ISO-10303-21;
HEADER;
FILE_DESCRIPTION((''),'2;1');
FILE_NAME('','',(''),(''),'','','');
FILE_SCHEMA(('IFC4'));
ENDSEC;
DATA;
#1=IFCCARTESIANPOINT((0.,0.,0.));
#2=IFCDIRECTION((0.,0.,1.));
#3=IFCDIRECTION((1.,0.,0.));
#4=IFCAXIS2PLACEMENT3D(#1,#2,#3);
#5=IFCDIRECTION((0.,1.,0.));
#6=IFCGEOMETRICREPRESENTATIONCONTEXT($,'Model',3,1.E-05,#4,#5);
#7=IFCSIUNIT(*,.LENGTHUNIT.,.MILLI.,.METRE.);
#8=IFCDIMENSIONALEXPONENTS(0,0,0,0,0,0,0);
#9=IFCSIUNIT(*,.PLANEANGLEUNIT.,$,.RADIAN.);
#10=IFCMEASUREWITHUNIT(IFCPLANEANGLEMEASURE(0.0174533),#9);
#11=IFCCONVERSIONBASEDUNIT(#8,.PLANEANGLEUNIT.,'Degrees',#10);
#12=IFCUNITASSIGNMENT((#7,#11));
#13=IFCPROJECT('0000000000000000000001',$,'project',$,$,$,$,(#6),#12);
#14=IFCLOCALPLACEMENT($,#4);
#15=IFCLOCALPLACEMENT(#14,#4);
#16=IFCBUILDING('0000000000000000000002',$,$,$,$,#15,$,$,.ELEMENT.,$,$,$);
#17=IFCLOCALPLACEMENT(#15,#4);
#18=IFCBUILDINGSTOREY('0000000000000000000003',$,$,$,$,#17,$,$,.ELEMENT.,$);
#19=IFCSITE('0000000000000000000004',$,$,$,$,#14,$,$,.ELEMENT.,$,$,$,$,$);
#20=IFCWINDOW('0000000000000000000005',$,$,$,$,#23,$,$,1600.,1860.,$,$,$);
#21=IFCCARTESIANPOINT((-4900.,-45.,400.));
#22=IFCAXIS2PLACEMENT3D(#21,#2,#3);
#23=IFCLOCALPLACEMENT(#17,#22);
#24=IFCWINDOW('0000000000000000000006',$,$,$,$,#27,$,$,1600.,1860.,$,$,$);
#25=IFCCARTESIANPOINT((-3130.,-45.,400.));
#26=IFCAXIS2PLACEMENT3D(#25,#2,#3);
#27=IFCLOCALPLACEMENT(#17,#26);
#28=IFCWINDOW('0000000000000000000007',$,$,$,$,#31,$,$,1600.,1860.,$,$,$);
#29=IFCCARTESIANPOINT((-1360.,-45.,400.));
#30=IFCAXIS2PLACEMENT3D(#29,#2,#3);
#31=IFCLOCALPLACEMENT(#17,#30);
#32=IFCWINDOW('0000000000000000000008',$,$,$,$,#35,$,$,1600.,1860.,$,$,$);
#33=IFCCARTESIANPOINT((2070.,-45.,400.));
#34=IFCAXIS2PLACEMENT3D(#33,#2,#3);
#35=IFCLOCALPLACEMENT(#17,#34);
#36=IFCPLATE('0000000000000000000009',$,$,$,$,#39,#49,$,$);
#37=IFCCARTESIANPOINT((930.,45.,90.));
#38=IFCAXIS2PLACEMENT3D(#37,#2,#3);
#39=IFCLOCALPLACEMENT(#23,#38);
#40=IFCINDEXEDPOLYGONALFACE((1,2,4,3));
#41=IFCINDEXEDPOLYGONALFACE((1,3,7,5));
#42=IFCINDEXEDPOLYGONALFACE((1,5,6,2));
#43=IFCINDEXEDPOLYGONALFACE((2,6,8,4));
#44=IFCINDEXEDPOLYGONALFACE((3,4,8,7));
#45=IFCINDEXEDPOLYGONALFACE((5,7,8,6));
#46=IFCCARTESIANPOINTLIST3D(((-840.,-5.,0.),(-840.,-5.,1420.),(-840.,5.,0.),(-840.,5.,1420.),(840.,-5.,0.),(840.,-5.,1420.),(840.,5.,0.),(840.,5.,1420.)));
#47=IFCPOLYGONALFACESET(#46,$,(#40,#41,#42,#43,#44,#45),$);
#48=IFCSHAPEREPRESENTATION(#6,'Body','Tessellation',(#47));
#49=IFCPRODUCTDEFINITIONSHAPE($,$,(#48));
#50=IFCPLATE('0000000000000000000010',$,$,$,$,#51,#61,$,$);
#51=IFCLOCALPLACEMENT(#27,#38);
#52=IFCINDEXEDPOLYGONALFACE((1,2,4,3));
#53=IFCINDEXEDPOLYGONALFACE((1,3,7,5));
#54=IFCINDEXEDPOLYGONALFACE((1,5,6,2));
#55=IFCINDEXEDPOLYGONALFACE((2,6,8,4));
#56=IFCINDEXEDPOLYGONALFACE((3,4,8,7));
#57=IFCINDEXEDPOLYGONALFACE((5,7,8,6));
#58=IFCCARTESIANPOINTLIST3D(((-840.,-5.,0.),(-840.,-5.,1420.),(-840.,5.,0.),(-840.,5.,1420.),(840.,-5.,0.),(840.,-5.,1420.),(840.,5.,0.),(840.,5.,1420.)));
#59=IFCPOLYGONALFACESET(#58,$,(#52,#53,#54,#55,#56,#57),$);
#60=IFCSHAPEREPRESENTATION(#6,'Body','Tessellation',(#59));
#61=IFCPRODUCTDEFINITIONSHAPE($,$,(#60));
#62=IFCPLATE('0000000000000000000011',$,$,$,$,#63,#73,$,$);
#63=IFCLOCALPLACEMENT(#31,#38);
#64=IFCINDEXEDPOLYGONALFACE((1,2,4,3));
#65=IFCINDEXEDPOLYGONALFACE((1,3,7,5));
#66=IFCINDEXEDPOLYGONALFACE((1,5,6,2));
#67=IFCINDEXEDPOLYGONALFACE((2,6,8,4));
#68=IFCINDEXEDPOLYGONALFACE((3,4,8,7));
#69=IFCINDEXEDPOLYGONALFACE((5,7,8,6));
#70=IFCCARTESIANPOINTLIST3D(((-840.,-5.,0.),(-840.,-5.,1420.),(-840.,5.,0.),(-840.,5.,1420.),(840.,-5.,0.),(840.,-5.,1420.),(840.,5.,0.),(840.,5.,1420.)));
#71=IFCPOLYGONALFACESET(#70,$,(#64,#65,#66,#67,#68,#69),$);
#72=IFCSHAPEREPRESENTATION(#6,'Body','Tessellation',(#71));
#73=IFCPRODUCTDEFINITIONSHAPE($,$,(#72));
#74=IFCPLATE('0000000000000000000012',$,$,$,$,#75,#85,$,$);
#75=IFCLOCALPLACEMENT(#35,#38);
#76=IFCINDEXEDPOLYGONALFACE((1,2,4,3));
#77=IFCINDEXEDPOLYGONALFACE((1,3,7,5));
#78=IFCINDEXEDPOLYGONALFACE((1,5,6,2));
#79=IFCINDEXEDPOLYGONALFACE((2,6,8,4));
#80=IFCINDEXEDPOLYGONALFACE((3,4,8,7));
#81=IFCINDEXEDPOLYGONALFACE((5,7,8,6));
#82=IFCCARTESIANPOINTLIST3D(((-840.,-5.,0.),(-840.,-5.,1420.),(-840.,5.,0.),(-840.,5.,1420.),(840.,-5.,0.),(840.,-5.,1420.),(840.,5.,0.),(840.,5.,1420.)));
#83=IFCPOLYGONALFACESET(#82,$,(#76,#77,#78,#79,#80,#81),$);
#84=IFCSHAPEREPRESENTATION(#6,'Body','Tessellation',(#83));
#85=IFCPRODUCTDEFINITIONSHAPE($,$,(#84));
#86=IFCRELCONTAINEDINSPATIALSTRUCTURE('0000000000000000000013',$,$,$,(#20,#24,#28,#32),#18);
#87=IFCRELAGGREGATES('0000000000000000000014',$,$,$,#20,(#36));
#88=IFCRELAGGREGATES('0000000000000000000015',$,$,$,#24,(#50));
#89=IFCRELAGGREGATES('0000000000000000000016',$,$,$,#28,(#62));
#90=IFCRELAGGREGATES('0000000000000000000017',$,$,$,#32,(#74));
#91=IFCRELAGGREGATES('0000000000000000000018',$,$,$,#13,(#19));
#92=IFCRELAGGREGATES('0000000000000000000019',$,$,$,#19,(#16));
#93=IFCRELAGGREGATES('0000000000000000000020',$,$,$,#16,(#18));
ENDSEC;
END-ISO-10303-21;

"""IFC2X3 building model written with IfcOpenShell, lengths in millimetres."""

from ifc_helpers import new_model, entity, si_unit, converted_unit, direction, frame, origin_with_axes, place, context, project, spatial, polyline, outline, extrude, element, aggregate, save


model = new_model("IFC2X3")

# Units and contexts
model_context = context("Model", 3, precision=1e-05, world=origin_with_axes(), true_north=direction((0.0, 1.0, 0.0)))
ifc_project = project(units=[si_unit("LENGTHUNIT", "METRE", prefix="MILLI"), converted_unit("PLANEANGLEUNIT", "Degrees", entity("IfcPlaneAngleMeasure", 0.0174533), si_unit("PLANEANGLEUNIT", "RADIAN"), dimensions=[0, 0, 0, 0, 0, 0, 0])], contexts=[model_context])

# Site, building, storey
placement = place(None, origin_with_axes())
site = spatial("IfcSite", under=ifc_project, at=placement, CompositionType="ELEMENT")
building_placement = place(placement, origin_with_axes())
building = spatial("IfcBuilding", under=site, at=building_placement, CompositionType="ELEMENT")
storey_placement = place(building_placement, origin_with_axes())
storey = spatial("IfcBuildingStorey", under=building, at=storey_placement, CompositionType="ELEMENT")

# Windows
window_1_placement = place(storey_placement, frame((-4900.0, -45.0, 400.0), z_axis=(0.0, 0.0, 1.0), x_axis=(1.0, 0.0, 0.0)))
window_1 = element("IfcWindow", 1, at=window_1_placement, inside=storey, OverallHeight=1600.0, OverallWidth=1860.0)
window_2_placement = place(storey_placement, frame((-3130.0, -45.0, 400.0), z_axis=(0.0, 0.0, 1.0), x_axis=(1.0, 0.0, 0.0)))
window_2 = element("IfcWindow", 2, at=window_2_placement, inside=storey, OverallHeight=1600.0, OverallWidth=1860.0)
window_3_placement = place(storey_placement, frame((-1360.0, -45.0, 400.0), z_axis=(0.0, 0.0, 1.0), x_axis=(1.0, 0.0, 0.0)))
window_3 = element("IfcWindow", 3, at=window_3_placement, inside=storey, OverallHeight=1600.0, OverallWidth=1860.0)
window_4_placement = place(storey_placement, frame((2070.0, -45.0, 400.0), z_axis=(0.0, 0.0, 1.0), x_axis=(1.0, 0.0, 0.0)))
window_4 = element("IfcWindow", 4, at=window_4_placement, inside=storey, OverallHeight=1600.0, OverallWidth=1860.0)

# Plates
plate_1_placement = place(window_1_placement, frame((930.0, 45.0, 90.0), z_axis=(0.0, 0.0, 1.0), x_axis=(1.0, 0.0, 0.0)))
plate_1 = element("IfcPlate", 5, at=plate_1_placement, context=model_context, shape_type="SweptSolid", body=[
    extrude(outline(polyline([(-840.0, -5.0), (840.0, -5.0), (840.0, 5.0), (-840.0, 5.0), (-840.0, -5.0), (-840.0, -5.0)])), origin_with_axes(), (0.0, 0.0, 1.0), 1420.0),
])
aggregate(window_1, [plate_1])
plate_2_placement = place(window_2_placement, frame((930.0, 45.0, 90.0), z_axis=(0.0, 0.0, 1.0), x_axis=(1.0, 0.0, 0.0)))
plate_2 = element("IfcPlate", 6, at=plate_2_placement, context=model_context, shape_type="SweptSolid", body=[
    extrude(outline(polyline([(-840.0, -5.0), (840.0, -5.0), (840.0, 5.0), (-840.0, 5.0), (-840.0, -5.0), (-840.0, -5.0)])), origin_with_axes(), (0.0, 0.0, 1.0), 1420.0),
])
aggregate(window_2, [plate_2])
plate_3_placement = place(window_3_placement, frame((930.0, 45.0, 90.0), z_axis=(0.0, 0.0, 1.0), x_axis=(1.0, 0.0, 0.0)))
plate_3 = element("IfcPlate", 7, at=plate_3_placement, context=model_context, shape_type="SweptSolid", body=[
    extrude(outline(polyline([(-840.0, -5.0), (840.0, -5.0), (840.0, 5.0), (-840.0, 5.0), (-840.0, -5.0), (-840.0, -5.0)])), origin_with_axes(), (0.0, 0.0, 1.0), 1420.0),
])
aggregate(window_3, [plate_3])
plate_4_placement = place(window_4_placement, frame((930.0, 45.0, 90.0), z_axis=(0.0, 0.0, 1.0), x_axis=(1.0, 0.0, 0.0)))
plate_4 = element("IfcPlate", 8, at=plate_4_placement, context=model_context, shape_type="SweptSolid", body=[
    extrude(outline(polyline([(-840.0, -5.0), (840.0, -5.0), (840.0, 5.0), (-840.0, 5.0), (-840.0, -5.0), (-840.0, -5.0)])), origin_with_axes(), (0.0, 0.0, 1.0), 1420.0),
])
aggregate(window_4, [plate_4])

save(model, "model.ifc")
